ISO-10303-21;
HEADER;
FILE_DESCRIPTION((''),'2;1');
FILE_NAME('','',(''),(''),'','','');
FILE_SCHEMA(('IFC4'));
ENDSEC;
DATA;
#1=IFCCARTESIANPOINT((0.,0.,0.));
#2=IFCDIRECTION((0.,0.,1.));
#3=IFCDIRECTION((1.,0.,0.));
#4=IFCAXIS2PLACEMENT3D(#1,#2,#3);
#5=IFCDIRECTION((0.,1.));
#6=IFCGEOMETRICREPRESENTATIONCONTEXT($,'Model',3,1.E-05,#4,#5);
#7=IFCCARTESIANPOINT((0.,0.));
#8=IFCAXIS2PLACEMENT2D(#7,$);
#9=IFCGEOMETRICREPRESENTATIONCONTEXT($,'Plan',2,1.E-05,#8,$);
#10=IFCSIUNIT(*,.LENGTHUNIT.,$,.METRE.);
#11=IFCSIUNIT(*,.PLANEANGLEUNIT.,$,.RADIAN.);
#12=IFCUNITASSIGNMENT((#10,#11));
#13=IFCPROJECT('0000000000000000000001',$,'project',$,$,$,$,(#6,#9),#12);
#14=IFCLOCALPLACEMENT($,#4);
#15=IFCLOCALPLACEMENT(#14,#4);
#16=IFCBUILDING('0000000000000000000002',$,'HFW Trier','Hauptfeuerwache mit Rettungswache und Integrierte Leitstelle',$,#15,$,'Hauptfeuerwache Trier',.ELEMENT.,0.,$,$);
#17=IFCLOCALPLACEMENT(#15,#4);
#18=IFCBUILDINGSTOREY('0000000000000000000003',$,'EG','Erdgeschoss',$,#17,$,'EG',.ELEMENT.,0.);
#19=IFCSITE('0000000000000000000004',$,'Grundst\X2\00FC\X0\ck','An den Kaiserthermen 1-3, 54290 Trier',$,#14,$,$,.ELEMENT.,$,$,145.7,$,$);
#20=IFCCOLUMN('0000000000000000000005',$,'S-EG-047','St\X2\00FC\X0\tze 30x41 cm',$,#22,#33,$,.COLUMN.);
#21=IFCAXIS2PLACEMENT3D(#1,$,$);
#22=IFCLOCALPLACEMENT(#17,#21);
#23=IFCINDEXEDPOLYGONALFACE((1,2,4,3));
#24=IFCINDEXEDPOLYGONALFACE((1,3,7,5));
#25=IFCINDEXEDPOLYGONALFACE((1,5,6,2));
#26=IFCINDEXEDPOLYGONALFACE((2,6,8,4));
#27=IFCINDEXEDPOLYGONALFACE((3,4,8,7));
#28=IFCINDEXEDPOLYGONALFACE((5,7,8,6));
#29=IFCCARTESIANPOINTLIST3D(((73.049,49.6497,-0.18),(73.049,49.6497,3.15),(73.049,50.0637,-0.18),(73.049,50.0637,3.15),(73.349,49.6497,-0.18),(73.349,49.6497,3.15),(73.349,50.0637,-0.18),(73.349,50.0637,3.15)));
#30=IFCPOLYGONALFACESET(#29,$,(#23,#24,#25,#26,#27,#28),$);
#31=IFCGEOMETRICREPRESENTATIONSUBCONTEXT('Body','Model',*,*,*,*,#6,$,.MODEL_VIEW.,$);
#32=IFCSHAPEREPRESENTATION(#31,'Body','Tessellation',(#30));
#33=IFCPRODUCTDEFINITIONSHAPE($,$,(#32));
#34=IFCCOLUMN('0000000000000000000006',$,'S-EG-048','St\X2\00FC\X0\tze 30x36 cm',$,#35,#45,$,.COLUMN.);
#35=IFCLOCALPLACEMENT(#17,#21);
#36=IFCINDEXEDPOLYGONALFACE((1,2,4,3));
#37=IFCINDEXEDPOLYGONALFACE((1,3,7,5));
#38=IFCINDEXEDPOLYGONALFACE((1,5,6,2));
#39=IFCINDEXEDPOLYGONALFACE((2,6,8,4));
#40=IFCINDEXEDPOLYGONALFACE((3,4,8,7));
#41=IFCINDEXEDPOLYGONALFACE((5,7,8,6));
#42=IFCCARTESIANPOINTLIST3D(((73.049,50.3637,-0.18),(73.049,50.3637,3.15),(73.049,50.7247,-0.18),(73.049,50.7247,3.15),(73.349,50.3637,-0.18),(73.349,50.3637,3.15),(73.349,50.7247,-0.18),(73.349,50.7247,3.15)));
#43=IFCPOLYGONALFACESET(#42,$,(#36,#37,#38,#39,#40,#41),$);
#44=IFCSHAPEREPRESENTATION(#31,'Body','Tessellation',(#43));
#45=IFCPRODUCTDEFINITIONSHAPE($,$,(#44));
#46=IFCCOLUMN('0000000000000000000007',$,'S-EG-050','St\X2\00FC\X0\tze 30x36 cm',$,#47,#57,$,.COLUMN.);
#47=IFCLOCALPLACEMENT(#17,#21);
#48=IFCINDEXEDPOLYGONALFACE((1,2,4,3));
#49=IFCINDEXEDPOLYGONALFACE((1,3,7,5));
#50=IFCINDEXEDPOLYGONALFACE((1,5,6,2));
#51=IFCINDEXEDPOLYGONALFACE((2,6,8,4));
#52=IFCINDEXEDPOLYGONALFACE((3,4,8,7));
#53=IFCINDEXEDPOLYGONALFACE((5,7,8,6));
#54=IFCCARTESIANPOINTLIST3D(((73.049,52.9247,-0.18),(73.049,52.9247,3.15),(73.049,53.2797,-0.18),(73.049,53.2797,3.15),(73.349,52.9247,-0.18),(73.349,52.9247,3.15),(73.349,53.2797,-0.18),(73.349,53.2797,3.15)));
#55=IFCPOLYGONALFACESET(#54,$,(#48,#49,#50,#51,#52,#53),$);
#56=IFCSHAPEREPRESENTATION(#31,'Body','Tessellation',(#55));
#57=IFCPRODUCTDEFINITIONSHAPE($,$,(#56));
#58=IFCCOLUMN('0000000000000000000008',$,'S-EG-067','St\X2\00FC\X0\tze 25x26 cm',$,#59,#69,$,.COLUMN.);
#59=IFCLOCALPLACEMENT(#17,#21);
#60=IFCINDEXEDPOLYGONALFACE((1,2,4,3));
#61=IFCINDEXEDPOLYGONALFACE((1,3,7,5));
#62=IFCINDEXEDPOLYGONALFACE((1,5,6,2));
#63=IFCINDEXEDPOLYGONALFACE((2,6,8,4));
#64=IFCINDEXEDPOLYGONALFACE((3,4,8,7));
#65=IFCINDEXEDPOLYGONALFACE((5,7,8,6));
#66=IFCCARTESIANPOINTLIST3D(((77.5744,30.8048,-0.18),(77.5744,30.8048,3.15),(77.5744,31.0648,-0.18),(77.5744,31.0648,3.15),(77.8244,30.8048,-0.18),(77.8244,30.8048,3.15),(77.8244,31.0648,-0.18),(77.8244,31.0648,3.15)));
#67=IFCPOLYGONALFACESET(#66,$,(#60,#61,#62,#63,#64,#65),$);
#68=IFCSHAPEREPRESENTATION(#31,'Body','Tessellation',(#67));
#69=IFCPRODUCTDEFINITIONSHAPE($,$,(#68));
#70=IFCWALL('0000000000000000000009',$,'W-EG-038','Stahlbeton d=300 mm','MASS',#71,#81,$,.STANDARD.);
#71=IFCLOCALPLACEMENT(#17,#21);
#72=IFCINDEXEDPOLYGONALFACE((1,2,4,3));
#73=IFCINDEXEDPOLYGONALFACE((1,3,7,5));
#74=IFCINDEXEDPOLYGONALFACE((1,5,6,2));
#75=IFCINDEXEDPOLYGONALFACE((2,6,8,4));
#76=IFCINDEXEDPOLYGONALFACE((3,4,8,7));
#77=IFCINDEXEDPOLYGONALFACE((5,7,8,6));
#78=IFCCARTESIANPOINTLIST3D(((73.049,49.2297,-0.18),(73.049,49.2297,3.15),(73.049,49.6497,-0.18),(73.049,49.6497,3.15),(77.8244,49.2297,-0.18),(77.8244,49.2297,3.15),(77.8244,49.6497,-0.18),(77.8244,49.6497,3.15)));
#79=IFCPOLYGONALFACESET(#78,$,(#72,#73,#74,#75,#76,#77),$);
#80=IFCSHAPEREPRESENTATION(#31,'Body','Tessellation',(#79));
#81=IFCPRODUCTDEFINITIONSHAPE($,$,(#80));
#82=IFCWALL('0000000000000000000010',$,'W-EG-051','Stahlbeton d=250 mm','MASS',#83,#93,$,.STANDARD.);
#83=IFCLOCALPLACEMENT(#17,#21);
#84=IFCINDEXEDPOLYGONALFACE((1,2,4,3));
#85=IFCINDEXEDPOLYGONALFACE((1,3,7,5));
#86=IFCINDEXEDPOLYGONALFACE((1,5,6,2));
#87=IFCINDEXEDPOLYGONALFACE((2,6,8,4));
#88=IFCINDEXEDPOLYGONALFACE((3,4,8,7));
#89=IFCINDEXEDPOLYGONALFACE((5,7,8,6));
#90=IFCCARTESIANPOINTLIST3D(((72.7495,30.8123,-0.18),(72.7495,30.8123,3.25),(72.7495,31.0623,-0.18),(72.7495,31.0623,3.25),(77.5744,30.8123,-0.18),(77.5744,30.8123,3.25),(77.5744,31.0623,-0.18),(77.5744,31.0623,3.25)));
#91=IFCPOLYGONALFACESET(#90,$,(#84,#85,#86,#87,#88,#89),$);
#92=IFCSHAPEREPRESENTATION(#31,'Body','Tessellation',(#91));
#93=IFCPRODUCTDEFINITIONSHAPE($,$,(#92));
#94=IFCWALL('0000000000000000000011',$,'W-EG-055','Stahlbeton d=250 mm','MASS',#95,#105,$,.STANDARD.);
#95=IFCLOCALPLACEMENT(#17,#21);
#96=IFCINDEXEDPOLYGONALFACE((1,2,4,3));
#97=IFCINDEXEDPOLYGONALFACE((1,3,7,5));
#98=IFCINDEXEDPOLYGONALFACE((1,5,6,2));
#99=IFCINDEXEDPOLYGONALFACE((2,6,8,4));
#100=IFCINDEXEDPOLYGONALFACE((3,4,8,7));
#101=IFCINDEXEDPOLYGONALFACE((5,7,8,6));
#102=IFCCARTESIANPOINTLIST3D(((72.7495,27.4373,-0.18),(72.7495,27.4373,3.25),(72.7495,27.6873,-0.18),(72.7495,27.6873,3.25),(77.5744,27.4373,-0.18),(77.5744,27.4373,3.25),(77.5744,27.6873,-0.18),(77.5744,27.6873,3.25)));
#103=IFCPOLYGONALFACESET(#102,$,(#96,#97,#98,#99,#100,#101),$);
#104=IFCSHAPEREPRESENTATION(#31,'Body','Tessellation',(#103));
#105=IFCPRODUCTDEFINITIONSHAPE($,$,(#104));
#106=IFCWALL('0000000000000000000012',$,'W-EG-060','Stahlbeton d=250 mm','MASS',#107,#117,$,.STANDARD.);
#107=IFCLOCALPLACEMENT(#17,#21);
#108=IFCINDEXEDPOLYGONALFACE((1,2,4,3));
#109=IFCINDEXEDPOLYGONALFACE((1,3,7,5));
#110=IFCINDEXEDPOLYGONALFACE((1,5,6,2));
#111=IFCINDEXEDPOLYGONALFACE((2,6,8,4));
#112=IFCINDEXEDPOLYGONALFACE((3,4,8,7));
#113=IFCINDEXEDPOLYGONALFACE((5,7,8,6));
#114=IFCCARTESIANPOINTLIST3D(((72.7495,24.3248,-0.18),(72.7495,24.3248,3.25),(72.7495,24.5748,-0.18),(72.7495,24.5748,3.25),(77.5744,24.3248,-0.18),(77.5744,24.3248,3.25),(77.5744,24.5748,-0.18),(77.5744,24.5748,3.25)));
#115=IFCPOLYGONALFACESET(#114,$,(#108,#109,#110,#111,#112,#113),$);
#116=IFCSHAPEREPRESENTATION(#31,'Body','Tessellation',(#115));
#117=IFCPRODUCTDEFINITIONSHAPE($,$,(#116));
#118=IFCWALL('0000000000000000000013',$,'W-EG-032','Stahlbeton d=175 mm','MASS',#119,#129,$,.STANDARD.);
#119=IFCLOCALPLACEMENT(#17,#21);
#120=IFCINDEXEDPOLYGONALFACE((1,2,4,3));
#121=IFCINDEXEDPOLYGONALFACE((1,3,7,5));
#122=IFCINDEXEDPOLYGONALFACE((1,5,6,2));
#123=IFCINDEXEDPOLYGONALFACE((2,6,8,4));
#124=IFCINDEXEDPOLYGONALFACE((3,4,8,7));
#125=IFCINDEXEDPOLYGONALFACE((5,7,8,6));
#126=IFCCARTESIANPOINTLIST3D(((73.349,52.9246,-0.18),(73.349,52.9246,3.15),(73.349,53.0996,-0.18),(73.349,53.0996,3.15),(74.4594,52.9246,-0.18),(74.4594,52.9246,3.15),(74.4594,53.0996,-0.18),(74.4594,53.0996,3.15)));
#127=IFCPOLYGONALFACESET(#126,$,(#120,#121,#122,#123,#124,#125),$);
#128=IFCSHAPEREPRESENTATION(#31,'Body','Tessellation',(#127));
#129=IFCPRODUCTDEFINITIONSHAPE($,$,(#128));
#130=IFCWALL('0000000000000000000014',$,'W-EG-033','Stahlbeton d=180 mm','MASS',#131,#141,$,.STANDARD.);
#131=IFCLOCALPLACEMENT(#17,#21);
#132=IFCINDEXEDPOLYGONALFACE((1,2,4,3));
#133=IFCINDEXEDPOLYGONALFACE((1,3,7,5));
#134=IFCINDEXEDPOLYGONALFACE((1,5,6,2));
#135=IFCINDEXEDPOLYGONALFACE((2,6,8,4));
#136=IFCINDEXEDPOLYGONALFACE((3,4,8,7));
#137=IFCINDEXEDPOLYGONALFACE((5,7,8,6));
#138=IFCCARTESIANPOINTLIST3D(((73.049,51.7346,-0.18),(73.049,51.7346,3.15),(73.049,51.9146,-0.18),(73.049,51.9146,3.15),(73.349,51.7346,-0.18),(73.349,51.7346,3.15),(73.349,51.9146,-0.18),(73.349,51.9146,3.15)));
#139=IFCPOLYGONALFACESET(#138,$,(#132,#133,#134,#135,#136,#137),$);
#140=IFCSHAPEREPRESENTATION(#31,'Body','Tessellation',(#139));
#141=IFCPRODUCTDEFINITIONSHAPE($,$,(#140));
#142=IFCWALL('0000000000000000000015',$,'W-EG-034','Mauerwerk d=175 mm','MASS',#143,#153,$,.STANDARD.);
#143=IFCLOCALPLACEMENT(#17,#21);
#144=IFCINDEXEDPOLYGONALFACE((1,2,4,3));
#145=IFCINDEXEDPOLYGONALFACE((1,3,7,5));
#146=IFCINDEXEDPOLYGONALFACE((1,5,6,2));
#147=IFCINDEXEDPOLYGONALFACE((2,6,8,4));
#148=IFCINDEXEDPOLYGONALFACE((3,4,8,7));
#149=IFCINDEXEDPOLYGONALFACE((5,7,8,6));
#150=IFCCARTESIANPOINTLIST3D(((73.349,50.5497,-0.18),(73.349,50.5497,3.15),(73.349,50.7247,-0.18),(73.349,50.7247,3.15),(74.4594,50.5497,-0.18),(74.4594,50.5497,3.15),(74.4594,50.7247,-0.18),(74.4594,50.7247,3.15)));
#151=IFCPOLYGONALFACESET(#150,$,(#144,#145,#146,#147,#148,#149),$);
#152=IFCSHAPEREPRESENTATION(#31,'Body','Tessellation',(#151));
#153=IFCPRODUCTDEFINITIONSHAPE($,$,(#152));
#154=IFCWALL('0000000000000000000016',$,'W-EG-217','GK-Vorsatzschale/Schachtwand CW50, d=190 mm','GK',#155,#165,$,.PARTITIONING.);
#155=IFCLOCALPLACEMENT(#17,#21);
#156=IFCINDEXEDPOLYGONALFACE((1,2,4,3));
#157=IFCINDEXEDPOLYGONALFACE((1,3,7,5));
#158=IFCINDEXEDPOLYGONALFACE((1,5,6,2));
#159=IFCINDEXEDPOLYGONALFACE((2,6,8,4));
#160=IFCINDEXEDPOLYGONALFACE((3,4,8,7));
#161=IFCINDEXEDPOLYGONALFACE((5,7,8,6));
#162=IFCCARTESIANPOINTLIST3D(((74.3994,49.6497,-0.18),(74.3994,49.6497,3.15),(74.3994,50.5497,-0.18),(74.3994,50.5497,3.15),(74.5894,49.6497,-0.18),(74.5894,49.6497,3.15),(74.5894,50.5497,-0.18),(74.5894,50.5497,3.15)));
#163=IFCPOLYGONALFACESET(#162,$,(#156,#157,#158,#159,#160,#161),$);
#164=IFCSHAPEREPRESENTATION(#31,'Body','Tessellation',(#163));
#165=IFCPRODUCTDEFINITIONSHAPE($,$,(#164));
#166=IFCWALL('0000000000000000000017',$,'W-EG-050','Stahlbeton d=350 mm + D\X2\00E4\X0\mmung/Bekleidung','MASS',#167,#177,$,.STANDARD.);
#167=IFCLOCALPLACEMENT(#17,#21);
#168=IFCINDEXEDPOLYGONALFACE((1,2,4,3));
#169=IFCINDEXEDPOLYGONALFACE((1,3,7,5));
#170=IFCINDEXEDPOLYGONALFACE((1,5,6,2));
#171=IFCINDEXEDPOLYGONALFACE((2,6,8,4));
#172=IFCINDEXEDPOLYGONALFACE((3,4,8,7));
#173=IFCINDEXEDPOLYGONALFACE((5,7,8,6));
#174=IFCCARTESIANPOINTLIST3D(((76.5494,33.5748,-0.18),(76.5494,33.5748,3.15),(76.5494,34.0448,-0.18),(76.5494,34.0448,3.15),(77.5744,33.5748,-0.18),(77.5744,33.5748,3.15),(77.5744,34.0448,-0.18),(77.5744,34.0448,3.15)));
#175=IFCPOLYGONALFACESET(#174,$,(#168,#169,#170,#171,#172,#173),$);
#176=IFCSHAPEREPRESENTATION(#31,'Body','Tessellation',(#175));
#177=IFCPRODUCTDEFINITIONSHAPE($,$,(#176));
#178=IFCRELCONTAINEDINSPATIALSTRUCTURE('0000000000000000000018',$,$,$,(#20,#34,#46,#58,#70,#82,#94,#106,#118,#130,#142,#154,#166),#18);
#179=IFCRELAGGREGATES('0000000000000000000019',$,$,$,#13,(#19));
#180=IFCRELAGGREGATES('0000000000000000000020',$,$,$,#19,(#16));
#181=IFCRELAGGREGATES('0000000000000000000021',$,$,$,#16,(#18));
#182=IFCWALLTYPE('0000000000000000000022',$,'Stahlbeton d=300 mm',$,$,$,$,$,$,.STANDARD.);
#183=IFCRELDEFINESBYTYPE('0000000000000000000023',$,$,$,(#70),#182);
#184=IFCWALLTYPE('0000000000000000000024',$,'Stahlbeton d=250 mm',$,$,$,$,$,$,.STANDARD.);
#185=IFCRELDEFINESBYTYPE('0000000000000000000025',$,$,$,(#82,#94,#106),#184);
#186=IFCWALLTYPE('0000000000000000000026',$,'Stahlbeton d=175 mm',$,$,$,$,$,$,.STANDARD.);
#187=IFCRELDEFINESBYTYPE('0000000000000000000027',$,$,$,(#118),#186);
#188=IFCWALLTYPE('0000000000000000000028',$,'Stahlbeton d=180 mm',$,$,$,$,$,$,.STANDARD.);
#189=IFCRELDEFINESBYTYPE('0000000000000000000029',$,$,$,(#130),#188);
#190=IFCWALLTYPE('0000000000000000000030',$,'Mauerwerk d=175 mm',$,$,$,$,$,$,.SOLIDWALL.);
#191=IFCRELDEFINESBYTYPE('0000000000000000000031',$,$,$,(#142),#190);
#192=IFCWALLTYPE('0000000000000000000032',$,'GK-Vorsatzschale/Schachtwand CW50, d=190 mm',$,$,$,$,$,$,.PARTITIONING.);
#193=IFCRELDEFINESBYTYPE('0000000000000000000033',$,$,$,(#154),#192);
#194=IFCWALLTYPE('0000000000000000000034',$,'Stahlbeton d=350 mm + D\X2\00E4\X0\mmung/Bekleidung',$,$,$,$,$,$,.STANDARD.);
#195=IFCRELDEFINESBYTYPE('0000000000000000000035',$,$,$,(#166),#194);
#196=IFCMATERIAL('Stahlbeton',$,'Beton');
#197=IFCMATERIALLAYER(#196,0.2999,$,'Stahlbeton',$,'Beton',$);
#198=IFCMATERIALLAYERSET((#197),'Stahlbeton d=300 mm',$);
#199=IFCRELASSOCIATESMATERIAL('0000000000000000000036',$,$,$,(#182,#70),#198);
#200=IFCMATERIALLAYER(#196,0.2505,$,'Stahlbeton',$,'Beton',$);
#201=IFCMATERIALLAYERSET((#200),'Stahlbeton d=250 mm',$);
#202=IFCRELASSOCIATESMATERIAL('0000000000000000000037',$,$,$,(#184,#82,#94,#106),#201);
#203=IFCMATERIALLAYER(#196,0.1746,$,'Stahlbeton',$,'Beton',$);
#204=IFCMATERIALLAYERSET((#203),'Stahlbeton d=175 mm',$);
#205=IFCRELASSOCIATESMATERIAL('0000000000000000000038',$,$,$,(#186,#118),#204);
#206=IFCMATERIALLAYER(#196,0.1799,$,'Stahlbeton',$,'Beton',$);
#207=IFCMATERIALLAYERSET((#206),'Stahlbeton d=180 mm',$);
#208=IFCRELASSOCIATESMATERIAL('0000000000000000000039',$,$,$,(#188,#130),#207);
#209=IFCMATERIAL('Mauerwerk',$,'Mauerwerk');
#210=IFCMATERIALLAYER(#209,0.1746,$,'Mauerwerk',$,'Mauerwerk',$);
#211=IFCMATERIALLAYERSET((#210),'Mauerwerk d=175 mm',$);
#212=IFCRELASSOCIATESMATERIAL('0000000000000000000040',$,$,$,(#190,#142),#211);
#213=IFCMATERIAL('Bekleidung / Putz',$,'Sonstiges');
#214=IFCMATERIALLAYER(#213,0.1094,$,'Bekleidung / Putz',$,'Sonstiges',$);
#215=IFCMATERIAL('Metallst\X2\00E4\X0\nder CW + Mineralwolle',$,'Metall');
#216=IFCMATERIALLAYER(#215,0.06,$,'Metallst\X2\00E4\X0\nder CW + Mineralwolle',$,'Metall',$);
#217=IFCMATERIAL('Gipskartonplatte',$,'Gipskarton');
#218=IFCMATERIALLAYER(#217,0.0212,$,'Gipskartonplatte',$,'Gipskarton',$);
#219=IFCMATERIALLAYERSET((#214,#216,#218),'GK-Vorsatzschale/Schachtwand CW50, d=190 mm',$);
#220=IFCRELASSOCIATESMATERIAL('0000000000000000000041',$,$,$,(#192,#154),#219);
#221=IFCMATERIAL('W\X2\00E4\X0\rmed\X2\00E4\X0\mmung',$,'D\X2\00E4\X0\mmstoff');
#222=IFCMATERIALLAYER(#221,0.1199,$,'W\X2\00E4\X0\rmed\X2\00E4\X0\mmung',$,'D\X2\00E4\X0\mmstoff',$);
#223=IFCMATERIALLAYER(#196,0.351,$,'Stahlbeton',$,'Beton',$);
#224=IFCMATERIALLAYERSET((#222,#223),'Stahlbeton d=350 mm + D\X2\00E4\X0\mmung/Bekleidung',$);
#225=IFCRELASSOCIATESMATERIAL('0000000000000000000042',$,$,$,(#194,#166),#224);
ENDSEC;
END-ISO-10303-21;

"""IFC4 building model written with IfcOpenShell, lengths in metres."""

from ifc_helpers import new_model, si_unit, direction, frame, frame_2d, origin_with_axes, origin_2d, place, context, subcontext, project, spatial, rectangle, extrude, material, layer, layer_set, layer_usage, type_object, element, save


model = new_model("IFC4")

# Units and contexts
model_context = context("Model", 3, precision=1e-05, world=origin_with_axes(), true_north=direction((0.0, 1.0)))
plan_context = context("Plan", 2, precision=1e-05, world=origin_2d())
body_context = subcontext(model_context, "Body", "Model", "MODEL_VIEW")
ifc_project = project(units=[si_unit("LENGTHUNIT", "METRE"), si_unit("PLANEANGLEUNIT", "RADIAN")], contexts=[model_context, plan_context])

# Site, building, storey
site_placement = place(None, origin_with_axes())
site = spatial("IfcSite", under=ifc_project, at=site_placement, Name="Grundstück", Description="An den Kaiserthermen 1-3, 54290 Trier", CompositionType="ELEMENT", RefElevation=145.7)
building_placement = place(site_placement, origin_with_axes())
building = spatial("IfcBuilding", under=site, at=building_placement, Name="HFW Trier", Description="Hauptfeuerwache mit Rettungswache und Integrierte Leitstelle", LongName="Hauptfeuerwache Trier", CompositionType="ELEMENT", ElevationOfRefHeight=0.0)
storey_placement = place(building_placement, origin_with_axes())
storey = spatial("IfcBuildingStorey", under=building, at=storey_placement, Name="EG", Description="Erdgeschoss", LongName="EG", CompositionType="ELEMENT", Elevation=0.0)

# Columns
column_1_placement = place(storey_placement, frame((73.049, 49.8567, -0.18), z_axis=(0.0, 0.0, 1.0), x_axis=(1.0, 0.0, 0.0)))
element("IfcColumn", 1, at=column_1_placement, inside=storey, Name="S-EG-047", Description="Stütze 30x41 cm", PredefinedType="COLUMN", context=body_context, shape_type="SweptSolid", body=[
    extrude(rectangle(XDim=0.3, YDim=0.414, at=frame_2d((0.15, 0.0))), origin_with_axes(), (0.0, 0.0, 1.0), 3.33),
])
column_2_placement = place(storey_placement, frame((73.049, 50.5442, -0.18), z_axis=(0.0, 0.0, 1.0), x_axis=(1.0, 0.0, 0.0)))
element("IfcColumn", 2, at=column_2_placement, inside=storey, Name="S-EG-048", Description="Stütze 30x36 cm", PredefinedType="COLUMN", context=body_context, shape_type="SweptSolid", body=[
    extrude(rectangle(XDim=0.3, YDim=0.361, at=frame_2d((0.15, 0.0))), origin_with_axes(), (0.0, 0.0, 1.0), 3.33),
])
column_3_placement = place(storey_placement, frame((73.049, 53.1022, -0.18), z_axis=(0.0, 0.0, 1.0), x_axis=(1.0, 0.0, 0.0)))
element("IfcColumn", 3, at=column_3_placement, inside=storey, Name="S-EG-050", Description="Stütze 30x36 cm", PredefinedType="COLUMN", context=body_context, shape_type="SweptSolid", body=[
    extrude(rectangle(XDim=0.3, YDim=0.355, at=frame_2d((0.15, 0.0))), origin_with_axes(), (0.0, 0.0, 1.0), 3.33),
])
column_4_placement = place(storey_placement, frame((77.5744, 30.9348, -0.18), z_axis=(0.0, 0.0, 1.0), x_axis=(1.0, 0.0, 0.0)))
element("IfcColumn", 4, at=column_4_placement, inside=storey, Name="S-EG-067", Description="Stütze 25x26 cm", PredefinedType="COLUMN", context=body_context, shape_type="SweptSolid", body=[
    extrude(rectangle(XDim=0.25, YDim=0.26, at=frame_2d((0.125, 0.0))), origin_with_axes(), (0.0, 0.0, 1.0), 3.33),
])

# Walls
ifc_material_1 = material(Name="Stahlbeton", Category="Beton")
ifc_layer_1 = layer(ifc_material_1, 0.2999, Name="Stahlbeton", Category="Beton")
ifc_layer_set_1 = layer_set([ifc_layer_1], Name="Stahlbeton d=300 mm")
ifc_layer_usage_1 = layer_usage(ifc_layer_set_1, "AXIS2", "POSITIVE", -0.21)
wall_type_1 = type_object("IfcWallType", Name="Stahlbeton d=300 mm", PredefinedType="STANDARD", material=ifc_layer_set_1)
wall_1_placement = place(storey_placement, frame((73.049, 49.4397, -0.18), z_axis=(0.0, 0.0, 1.0), x_axis=(1.0, 0.0, 0.0)))
element("IfcWall", 5, at=wall_1_placement, inside=storey, type_object=wall_type_1, material=ifc_layer_usage_1, Name="W-EG-038", Description="Stahlbeton d=300 mm", ObjectType="MASS", PredefinedType="STANDARD", context=body_context, shape_type="SweptSolid", body=[
    extrude(rectangle(XDim=4.7754, YDim=0.42, at=frame_2d((2.3877, 0.0))), origin_with_axes(), (0.0, 0.0, 1.0), 3.33),
])
ifc_layer_2 = layer(ifc_material_1, 0.2505, Name="Stahlbeton", Category="Beton")
ifc_layer_set_2 = layer_set([ifc_layer_2], Name="Stahlbeton d=250 mm")
ifc_layer_usage_2 = layer_usage(ifc_layer_set_2, "AXIS2", "POSITIVE", -0.125)
wall_type_2 = type_object("IfcWallType", Name="Stahlbeton d=250 mm", PredefinedType="STANDARD", material=ifc_layer_set_2)
wall_2_placement = place(storey_placement, frame((72.7495, 30.9373, -0.18), z_axis=(0.0, 0.0, 1.0), x_axis=(1.0, 0.0, 0.0)))
element("IfcWall", 6, at=wall_2_placement, inside=storey, type_object=wall_type_2, material=ifc_layer_usage_2, Name="W-EG-051", Description="Stahlbeton d=250 mm", ObjectType="MASS", PredefinedType="STANDARD", context=body_context, shape_type="SweptSolid", body=[
    extrude(rectangle(XDim=4.8249, YDim=0.25, at=frame_2d((2.4124, 0.0))), origin_with_axes(), (0.0, 0.0, 1.0), 3.43),
])
ifc_layer_usage_3 = layer_usage(ifc_layer_set_2, "AXIS2", "POSITIVE", -0.125)
wall_3_placement = place(storey_placement, frame((72.7495, 27.5623, -0.18), z_axis=(0.0, 0.0, 1.0), x_axis=(1.0, 0.0, 0.0)))
element("IfcWall", 7, at=wall_3_placement, inside=storey, type_object=wall_type_2, material=ifc_layer_usage_3, Name="W-EG-055", Description="Stahlbeton d=250 mm", ObjectType="MASS", PredefinedType="STANDARD", context=body_context, shape_type="SweptSolid", body=[
    extrude(rectangle(XDim=4.8249, YDim=0.25, at=frame_2d((2.4124, 0.0))), origin_with_axes(), (0.0, 0.0, 1.0), 3.43),
])
ifc_layer_usage_4 = layer_usage(ifc_layer_set_2, "AXIS2", "POSITIVE", -0.125)
wall_4_placement = place(storey_placement, frame((72.7495, 24.4498, -0.18), z_axis=(0.0, 0.0, 1.0), x_axis=(1.0, 0.0, 0.0)))
element("IfcWall", 8, at=wall_4_placement, inside=storey, type_object=wall_type_2, material=ifc_layer_usage_4, Name="W-EG-060", Description="Stahlbeton d=250 mm", ObjectType="MASS", PredefinedType="STANDARD", context=body_context, shape_type="SweptSolid", body=[
    extrude(rectangle(XDim=4.8249, YDim=0.25, at=frame_2d((2.4124, 0.0))), origin_with_axes(), (0.0, 0.0, 1.0), 3.43),
])
ifc_layer_3 = layer(ifc_material_1, 0.1746, Name="Stahlbeton", Category="Beton")
ifc_layer_set_3 = layer_set([ifc_layer_3], Name="Stahlbeton d=175 mm")
ifc_layer_usage_5 = layer_usage(ifc_layer_set_3, "AXIS2", "POSITIVE", -0.0875)
wall_type_3 = type_object("IfcWallType", Name="Stahlbeton d=175 mm", PredefinedType="STANDARD", material=ifc_layer_set_3)
wall_5_placement = place(storey_placement, frame((73.349, 53.0121, -0.18), z_axis=(0.0, 0.0, 1.0), x_axis=(1.0, 0.0, 0.0)))
element("IfcWall", 9, at=wall_5_placement, inside=storey, type_object=wall_type_3, material=ifc_layer_usage_5, Name="W-EG-032", Description="Stahlbeton d=175 mm", ObjectType="MASS", PredefinedType="STANDARD", context=body_context, shape_type="SweptSolid", body=[
    extrude(rectangle(XDim=1.1104, YDim=0.175, at=frame_2d((0.5552, 0.0))), origin_with_axes(), (0.0, 0.0, 1.0), 3.33),
])
ifc_layer_4 = layer(ifc_material_1, 0.1799, Name="Stahlbeton", Category="Beton")
ifc_layer_set_4 = layer_set([ifc_layer_4], Name="Stahlbeton d=180 mm")
ifc_layer_usage_6 = layer_usage(ifc_layer_set_4, "AXIS2", "POSITIVE", -0.09)
wall_type_4 = type_object("IfcWallType", Name="Stahlbeton d=180 mm", PredefinedType="STANDARD", material=ifc_layer_set_4)
wall_6_placement = place(storey_placement, frame((73.049, 51.8246, -0.18), z_axis=(0.0, 0.0, 1.0), x_axis=(1.0, 0.0, 0.0)))
element("IfcWall", 10, at=wall_6_placement, inside=storey, type_object=wall_type_4, material=ifc_layer_usage_6, Name="W-EG-033", Description="Stahlbeton d=180 mm", ObjectType="MASS", PredefinedType="STANDARD", context=body_context, shape_type="SweptSolid", body=[
    extrude(rectangle(XDim=0.3, YDim=0.18, at=frame_2d((0.15, 0.0))), origin_with_axes(), (0.0, 0.0, 1.0), 3.33),
])
ifc_material_2 = material(Name="Mauerwerk", Category="Mauerwerk")
ifc_layer_5 = layer(ifc_material_2, 0.1746, Name="Mauerwerk", Category="Mauerwerk")
ifc_layer_set_5 = layer_set([ifc_layer_5], Name="Mauerwerk d=175 mm")
ifc_layer_usage_7 = layer_usage(ifc_layer_set_5, "AXIS2", "POSITIVE", -0.0875)
wall_type_5 = type_object("IfcWallType", Name="Mauerwerk d=175 mm", PredefinedType="SOLIDWALL", material=ifc_layer_set_5)
wall_7_placement = place(storey_placement, frame((73.349, 50.6372, -0.18), z_axis=(0.0, 0.0, 1.0), x_axis=(1.0, 0.0, 0.0)))
element("IfcWall", 11, at=wall_7_placement, inside=storey, type_object=wall_type_5, material=ifc_layer_usage_7, Name="W-EG-034", Description="Mauerwerk d=175 mm", ObjectType="MASS", PredefinedType="STANDARD", context=body_context, shape_type="SweptSolid", body=[
    extrude(rectangle(XDim=1.1104, YDim=0.175, at=frame_2d((0.5552, 0.0))), origin_with_axes(), (0.0, 0.0, 1.0), 3.33),
])
ifc_material_3 = material(Name="Bekleidung / Putz", Category="Sonstiges")
ifc_layer_6 = layer(ifc_material_3, 0.1094, Name="Bekleidung / Putz", Category="Sonstiges")
ifc_material_4 = material(Name="Metallständer CW + Mineralwolle", Category="Metall")
ifc_layer_7 = layer(ifc_material_4, 0.06, Name="Metallständer CW + Mineralwolle", Category="Metall")
ifc_material_5 = material(Name="Gipskartonplatte", Category="Gipskarton")
ifc_layer_8 = layer(ifc_material_5, 0.0212, Name="Gipskartonplatte", Category="Gipskarton")
ifc_layer_set_6 = layer_set([ifc_layer_6, ifc_layer_7, ifc_layer_8], Name="GK-Vorsatzschale/Schachtwand CW50, d=190 mm")
ifc_layer_usage_8 = layer_usage(ifc_layer_set_6, "AXIS2", "POSITIVE", -0.095)
wall_type_6 = type_object("IfcWallType", Name="GK-Vorsatzschale/Schachtwand CW50, d=190 mm", PredefinedType="PARTITIONING", material=ifc_layer_set_6)
wall_8_placement = place(storey_placement, frame((74.4944, 50.5497, -0.18), z_axis=(0.0, 0.0, 1.0), x_axis=(0.0, -1.0, 0.0)))
element("IfcWall", 12, at=wall_8_placement, inside=storey, type_object=wall_type_6, material=ifc_layer_usage_8, Name="W-EG-217", Description="GK-Vorsatzschale/Schachtwand CW50, d=190 mm", ObjectType="GK", PredefinedType="PARTITIONING", context=body_context, shape_type="SweptSolid", body=[
    extrude(rectangle(XDim=0.9, YDim=0.19, at=frame_2d((0.45, 0.0))), origin_with_axes(), (0.0, 0.0, 1.0), 3.33),
])
ifc_material_6 = material(Name="Wärmedämmung", Category="Dämmstoff")
ifc_layer_9 = layer(ifc_material_6, 0.1199, Name="Wärmedämmung", Category="Dämmstoff")
ifc_layer_10 = layer(ifc_material_1, 0.351, Name="Stahlbeton", Category="Beton")
ifc_layer_set_7 = layer_set([ifc_layer_9, ifc_layer_10], Name="Stahlbeton d=350 mm + Dämmung/Bekleidung")
ifc_layer_usage_9 = layer_usage(ifc_layer_set_7, "AXIS2", "POSITIVE", -0.235)
wall_type_7 = type_object("IfcWallType", Name="Stahlbeton d=350 mm + Dämmung/Bekleidung", PredefinedType="STANDARD", material=ifc_layer_set_7)
wall_9_placement = place(storey_placement, frame((76.5494, 33.8098, -0.18), z_axis=(0.0, 0.0, 1.0), x_axis=(1.0, 0.0, 0.0)))
element("IfcWall", 13, at=wall_9_placement, inside=storey, type_object=wall_type_7, material=ifc_layer_usage_9, Name="W-EG-050", Description="Stahlbeton d=350 mm + Dämmung/Bekleidung", ObjectType="MASS", PredefinedType="STANDARD", context=body_context, shape_type="SweptSolid", body=[
    extrude(rectangle(XDim=1.025, YDim=0.47, at=frame_2d((0.5125, 0.0))), origin_with_axes(), (0.0, 0.0, 1.0), 3.33),
])

save(model, "model.ifc")
